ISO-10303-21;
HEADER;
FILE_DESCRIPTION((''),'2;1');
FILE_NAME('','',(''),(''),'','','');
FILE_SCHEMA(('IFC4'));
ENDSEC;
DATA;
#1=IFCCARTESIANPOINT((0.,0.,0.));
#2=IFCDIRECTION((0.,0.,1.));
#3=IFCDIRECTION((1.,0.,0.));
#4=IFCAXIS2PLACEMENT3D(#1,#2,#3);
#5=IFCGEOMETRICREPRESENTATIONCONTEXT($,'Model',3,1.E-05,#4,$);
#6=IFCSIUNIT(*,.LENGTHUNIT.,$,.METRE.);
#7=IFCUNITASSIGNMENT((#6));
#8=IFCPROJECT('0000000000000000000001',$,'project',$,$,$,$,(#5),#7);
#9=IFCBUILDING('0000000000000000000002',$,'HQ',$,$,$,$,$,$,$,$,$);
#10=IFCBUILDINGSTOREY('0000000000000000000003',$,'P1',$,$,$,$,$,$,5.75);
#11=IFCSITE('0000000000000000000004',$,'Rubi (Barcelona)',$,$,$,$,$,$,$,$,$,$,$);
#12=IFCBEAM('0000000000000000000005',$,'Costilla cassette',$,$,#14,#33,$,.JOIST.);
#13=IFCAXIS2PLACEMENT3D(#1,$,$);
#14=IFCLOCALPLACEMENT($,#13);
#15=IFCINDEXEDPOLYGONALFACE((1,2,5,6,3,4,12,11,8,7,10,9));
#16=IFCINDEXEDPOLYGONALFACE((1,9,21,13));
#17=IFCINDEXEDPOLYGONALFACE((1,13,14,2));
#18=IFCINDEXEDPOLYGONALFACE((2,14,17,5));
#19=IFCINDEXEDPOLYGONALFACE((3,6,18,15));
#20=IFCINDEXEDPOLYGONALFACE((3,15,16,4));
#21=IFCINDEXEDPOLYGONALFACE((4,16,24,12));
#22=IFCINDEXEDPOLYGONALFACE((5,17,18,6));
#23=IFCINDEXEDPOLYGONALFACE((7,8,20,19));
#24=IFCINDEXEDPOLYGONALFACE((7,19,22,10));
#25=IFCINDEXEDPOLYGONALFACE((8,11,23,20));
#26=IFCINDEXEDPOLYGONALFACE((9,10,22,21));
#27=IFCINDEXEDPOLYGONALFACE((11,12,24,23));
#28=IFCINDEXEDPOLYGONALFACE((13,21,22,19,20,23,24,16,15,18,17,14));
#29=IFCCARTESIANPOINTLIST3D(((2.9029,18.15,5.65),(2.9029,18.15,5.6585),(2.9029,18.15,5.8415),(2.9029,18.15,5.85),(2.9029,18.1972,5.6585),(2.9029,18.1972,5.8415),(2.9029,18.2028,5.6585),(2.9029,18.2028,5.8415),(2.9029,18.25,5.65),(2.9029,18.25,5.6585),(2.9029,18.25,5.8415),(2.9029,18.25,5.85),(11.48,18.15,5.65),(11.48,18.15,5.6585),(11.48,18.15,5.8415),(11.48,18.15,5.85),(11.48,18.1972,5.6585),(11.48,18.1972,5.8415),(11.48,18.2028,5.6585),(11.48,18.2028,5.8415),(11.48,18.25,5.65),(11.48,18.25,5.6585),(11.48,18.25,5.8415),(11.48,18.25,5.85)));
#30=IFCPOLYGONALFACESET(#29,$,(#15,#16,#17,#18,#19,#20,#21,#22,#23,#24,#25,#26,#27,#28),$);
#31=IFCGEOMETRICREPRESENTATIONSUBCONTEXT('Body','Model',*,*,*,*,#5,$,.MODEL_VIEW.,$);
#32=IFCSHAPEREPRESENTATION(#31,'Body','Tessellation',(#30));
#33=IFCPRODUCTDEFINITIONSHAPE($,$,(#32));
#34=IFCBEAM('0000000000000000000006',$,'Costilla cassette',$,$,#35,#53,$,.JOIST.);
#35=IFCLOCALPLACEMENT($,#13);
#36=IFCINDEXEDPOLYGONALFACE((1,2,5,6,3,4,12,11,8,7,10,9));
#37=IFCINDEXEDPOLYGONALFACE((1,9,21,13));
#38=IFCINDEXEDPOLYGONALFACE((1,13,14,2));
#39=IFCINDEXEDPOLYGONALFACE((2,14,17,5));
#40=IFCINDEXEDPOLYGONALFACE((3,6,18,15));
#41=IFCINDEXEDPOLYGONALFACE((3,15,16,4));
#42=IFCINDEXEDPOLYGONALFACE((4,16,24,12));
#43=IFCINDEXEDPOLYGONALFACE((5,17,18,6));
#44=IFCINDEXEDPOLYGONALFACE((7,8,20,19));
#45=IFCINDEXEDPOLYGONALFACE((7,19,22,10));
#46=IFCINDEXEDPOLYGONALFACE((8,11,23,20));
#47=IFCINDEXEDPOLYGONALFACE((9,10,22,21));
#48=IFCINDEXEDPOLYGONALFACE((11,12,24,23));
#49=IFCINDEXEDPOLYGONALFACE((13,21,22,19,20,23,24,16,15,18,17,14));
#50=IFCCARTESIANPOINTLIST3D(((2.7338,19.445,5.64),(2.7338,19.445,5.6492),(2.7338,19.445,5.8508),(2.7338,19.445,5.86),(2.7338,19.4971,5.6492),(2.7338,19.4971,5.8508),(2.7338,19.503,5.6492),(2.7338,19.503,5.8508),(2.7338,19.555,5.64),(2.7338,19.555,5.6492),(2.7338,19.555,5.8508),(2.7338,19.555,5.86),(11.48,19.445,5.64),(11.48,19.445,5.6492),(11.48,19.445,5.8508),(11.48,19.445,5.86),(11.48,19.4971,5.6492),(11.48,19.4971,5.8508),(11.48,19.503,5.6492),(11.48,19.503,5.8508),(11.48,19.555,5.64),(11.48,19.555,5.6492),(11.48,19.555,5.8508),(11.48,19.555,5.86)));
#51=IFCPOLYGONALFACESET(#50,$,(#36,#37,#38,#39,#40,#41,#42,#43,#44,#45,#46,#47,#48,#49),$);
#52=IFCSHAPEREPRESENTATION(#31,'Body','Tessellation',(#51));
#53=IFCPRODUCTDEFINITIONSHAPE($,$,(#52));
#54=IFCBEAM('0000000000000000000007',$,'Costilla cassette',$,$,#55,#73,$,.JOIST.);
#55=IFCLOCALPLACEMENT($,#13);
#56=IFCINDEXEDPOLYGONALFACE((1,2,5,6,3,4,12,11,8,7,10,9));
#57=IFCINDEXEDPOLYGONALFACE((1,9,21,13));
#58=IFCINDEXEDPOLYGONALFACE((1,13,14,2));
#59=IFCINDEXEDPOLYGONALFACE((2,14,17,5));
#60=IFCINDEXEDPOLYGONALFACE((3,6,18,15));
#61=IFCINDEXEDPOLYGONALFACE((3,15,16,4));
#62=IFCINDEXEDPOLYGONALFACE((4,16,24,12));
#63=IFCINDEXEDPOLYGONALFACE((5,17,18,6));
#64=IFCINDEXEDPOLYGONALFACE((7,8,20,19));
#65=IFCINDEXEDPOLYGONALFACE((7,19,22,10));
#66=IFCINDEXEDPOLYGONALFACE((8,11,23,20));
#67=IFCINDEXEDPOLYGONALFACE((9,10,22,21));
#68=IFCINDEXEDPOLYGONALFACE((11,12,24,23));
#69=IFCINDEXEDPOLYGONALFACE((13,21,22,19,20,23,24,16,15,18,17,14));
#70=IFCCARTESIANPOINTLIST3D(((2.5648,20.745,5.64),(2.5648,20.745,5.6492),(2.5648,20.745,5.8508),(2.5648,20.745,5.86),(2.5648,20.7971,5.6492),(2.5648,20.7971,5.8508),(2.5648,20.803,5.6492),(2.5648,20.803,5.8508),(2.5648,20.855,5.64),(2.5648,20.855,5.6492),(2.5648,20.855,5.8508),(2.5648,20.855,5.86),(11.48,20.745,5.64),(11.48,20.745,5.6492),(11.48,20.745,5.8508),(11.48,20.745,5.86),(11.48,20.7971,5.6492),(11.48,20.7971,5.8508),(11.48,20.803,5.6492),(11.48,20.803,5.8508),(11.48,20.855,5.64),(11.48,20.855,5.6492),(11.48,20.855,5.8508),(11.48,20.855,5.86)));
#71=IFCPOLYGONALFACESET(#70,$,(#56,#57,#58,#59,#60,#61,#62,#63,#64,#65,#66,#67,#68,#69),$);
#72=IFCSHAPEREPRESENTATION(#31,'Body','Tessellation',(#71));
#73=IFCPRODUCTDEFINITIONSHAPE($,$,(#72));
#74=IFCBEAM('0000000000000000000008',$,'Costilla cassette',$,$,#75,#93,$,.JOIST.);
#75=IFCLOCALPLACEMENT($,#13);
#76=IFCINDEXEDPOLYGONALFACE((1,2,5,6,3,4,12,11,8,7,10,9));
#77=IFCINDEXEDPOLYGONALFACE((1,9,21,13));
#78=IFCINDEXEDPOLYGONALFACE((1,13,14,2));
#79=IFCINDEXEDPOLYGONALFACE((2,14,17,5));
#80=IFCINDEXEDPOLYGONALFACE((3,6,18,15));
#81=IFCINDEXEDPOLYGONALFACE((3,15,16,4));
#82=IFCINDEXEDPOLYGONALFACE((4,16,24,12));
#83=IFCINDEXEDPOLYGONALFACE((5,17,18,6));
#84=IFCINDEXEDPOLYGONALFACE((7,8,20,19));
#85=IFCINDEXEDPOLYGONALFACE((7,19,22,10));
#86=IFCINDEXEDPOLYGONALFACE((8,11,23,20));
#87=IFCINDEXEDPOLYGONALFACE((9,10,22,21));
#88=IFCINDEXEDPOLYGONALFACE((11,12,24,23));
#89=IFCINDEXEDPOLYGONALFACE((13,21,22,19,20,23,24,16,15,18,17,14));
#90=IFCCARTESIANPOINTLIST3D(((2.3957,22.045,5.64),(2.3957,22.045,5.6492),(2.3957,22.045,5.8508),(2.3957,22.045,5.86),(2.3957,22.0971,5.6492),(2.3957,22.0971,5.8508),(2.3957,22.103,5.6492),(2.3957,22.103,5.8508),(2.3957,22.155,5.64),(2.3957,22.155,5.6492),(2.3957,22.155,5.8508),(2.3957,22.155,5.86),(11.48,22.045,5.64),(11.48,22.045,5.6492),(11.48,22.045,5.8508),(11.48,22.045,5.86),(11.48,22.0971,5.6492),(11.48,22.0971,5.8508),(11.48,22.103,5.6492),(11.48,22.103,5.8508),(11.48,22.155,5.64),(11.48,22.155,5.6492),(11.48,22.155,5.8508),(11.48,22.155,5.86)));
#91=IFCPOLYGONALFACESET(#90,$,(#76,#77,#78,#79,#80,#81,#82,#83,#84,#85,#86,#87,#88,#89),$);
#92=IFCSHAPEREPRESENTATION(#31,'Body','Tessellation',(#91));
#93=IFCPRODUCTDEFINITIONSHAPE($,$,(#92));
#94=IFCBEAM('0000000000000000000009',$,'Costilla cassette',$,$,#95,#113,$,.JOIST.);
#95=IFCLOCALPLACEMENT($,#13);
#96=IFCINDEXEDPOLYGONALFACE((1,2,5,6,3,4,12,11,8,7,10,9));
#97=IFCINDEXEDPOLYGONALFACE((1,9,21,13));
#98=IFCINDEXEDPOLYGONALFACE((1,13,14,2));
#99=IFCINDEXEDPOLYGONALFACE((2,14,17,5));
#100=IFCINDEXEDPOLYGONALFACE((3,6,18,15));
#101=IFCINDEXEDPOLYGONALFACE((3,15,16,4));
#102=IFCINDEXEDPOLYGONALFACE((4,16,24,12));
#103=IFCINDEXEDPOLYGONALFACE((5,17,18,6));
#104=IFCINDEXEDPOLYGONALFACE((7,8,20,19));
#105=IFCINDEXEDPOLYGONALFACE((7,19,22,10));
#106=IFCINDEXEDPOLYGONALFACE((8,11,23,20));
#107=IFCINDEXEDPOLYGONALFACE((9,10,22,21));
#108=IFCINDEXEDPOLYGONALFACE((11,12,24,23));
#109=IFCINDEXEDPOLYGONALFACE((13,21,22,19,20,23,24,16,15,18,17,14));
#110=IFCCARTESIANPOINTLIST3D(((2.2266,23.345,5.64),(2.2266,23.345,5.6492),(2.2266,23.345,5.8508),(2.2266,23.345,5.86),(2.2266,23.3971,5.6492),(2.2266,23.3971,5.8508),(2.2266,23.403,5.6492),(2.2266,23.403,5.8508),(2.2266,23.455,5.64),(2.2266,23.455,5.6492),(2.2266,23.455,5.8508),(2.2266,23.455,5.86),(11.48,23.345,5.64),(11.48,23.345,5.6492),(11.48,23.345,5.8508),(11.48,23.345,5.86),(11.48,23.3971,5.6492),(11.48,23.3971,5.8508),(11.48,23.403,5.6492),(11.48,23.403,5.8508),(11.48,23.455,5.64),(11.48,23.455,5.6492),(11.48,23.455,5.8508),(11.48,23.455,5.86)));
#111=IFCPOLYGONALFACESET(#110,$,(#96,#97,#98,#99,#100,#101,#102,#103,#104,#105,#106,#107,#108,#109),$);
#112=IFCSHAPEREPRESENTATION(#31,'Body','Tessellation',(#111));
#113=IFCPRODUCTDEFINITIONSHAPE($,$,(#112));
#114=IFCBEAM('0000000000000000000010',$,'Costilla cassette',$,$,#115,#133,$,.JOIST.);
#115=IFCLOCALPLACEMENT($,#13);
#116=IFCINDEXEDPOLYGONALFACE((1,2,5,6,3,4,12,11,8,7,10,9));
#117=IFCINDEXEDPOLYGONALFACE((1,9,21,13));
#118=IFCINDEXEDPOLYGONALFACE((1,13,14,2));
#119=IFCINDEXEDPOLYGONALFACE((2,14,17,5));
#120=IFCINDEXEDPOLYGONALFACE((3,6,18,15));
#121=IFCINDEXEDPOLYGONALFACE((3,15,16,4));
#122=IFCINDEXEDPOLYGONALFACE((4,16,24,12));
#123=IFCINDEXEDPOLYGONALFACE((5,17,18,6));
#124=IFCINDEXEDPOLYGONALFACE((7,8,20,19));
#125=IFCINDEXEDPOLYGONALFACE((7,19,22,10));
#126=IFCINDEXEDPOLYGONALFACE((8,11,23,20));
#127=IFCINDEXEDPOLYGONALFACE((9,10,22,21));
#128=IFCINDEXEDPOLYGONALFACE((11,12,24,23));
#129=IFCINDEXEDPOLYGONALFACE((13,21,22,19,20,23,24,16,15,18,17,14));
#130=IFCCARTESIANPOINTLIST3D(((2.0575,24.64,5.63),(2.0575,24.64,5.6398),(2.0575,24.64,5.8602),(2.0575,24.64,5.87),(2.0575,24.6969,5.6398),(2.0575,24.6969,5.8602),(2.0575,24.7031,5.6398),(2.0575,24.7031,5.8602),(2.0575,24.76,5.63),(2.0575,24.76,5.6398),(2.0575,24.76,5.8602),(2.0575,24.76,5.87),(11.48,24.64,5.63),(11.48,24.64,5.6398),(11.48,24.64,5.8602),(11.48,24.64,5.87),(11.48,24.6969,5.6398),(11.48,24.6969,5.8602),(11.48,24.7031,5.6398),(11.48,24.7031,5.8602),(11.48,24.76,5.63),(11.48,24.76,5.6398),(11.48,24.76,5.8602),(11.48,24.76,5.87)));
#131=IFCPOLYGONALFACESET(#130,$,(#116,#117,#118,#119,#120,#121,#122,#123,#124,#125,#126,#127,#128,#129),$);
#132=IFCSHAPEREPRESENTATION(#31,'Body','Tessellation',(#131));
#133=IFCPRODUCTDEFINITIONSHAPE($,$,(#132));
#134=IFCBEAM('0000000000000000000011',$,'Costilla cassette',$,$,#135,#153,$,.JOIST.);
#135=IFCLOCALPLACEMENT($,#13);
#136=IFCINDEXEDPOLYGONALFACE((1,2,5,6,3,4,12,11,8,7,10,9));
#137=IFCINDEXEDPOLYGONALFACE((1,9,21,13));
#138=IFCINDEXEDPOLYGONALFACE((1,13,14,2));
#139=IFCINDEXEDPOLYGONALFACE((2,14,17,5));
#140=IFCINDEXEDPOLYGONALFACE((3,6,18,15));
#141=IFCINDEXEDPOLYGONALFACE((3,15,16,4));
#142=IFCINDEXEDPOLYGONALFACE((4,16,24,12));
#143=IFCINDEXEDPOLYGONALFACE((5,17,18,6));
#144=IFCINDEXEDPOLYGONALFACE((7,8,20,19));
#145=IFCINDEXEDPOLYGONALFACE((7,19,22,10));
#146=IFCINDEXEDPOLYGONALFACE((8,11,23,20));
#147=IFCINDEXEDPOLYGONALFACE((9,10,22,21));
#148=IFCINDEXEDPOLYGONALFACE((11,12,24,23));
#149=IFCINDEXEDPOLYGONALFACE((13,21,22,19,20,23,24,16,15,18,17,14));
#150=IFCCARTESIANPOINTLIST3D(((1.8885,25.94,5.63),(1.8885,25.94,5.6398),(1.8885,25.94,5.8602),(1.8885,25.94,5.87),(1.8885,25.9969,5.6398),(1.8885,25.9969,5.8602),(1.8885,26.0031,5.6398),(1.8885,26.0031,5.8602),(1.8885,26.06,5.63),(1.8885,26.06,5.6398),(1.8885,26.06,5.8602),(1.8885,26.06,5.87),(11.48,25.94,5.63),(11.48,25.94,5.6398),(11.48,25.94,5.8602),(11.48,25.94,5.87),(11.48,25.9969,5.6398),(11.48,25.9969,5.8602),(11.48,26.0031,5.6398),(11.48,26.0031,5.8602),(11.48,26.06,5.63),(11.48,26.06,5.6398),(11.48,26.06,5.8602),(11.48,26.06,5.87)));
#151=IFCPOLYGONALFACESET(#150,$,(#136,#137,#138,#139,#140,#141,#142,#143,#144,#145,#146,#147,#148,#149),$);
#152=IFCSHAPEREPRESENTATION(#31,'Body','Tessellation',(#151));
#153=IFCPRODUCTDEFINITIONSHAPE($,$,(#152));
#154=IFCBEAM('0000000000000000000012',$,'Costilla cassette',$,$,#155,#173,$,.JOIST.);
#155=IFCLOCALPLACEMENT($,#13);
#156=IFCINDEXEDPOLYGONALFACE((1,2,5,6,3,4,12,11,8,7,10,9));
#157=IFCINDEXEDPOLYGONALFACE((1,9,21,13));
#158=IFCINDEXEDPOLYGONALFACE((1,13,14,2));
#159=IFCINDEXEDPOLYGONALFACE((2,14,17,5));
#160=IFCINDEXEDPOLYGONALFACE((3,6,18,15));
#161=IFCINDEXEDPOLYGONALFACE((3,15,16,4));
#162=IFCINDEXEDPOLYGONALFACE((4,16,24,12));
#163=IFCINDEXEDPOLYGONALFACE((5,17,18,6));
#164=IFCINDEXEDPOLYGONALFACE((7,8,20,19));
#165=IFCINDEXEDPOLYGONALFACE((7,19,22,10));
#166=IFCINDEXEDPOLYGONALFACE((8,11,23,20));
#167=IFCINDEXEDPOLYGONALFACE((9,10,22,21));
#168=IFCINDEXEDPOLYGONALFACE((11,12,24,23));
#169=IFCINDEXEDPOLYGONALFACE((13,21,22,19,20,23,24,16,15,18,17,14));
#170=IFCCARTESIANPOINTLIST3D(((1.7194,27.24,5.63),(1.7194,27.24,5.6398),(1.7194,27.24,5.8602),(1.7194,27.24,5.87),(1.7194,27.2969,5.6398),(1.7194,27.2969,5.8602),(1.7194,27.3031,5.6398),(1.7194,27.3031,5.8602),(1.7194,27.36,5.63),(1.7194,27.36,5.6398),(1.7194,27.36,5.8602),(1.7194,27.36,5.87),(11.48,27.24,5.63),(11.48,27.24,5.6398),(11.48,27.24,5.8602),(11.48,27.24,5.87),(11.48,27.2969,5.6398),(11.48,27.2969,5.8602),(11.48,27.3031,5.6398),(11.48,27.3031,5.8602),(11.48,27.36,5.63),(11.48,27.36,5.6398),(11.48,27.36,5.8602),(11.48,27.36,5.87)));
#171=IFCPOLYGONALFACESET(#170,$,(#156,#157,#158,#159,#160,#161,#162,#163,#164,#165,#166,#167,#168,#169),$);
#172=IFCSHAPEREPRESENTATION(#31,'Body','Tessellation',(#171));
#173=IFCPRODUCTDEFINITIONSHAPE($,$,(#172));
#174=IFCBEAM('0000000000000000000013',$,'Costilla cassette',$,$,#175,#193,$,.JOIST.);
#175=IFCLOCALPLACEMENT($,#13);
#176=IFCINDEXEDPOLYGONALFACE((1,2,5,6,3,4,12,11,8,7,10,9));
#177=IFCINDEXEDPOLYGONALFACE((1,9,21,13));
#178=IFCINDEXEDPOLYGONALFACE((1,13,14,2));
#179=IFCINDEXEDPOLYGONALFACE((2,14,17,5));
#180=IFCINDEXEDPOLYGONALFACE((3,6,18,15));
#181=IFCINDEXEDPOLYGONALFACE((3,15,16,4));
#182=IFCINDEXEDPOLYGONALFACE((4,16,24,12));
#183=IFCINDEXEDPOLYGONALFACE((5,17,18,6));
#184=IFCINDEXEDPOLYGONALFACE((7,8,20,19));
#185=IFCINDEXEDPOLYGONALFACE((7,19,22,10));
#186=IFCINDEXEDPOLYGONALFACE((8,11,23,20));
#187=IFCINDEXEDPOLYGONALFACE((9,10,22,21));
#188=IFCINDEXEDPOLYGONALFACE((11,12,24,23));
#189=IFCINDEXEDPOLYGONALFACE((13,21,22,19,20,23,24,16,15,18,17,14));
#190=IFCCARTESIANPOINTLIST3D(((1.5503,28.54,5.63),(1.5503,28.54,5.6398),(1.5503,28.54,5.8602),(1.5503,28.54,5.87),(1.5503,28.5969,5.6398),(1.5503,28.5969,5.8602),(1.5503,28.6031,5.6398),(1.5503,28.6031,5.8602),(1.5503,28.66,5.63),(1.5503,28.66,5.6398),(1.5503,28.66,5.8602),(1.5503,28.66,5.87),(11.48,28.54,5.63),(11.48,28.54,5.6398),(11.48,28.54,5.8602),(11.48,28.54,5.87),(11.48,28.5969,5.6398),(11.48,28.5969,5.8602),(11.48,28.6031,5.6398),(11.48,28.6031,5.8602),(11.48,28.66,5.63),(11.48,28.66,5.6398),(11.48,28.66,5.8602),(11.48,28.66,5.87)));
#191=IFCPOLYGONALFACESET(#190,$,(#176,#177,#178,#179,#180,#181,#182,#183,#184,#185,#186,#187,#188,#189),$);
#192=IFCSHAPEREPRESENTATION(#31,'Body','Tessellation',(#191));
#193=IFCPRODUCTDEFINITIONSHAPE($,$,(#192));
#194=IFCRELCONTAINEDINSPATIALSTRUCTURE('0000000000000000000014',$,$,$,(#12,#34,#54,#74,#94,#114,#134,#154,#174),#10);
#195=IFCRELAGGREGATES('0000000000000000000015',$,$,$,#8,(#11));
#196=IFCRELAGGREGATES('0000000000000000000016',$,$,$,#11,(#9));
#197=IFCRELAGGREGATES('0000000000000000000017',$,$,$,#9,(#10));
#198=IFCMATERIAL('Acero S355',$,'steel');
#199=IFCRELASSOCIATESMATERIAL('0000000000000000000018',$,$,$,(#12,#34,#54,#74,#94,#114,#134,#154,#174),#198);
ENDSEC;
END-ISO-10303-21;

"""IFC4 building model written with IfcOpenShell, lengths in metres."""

from ifc_helpers import new_model, si_unit, frame, origin_with_axes, place, context, subcontext, project, spatial, i_section, extrude, material, element, save


model = new_model("IFC4")

# Units and contexts
model_context = context("Model", 3, precision=1e-05, world=origin_with_axes())
body_context = subcontext(model_context, "Body", "Model", "MODEL_VIEW")
ifc_project = project(units=[si_unit("LENGTHUNIT", "METRE")], contexts=[model_context])

# Site, building, storey
site = spatial("IfcSite", under=ifc_project, Name="Rubi (Barcelona)")
building = spatial("IfcBuilding", under=site, Name="HQ")
storey = spatial("IfcBuildingStorey", under=building, Name="P1", Elevation=5.75)

# Beams
ifc_material_1 = material(Name="Acero S355", Category="steel")
beam_1_placement = place(None, origin_with_axes())
element("IfcBeam", 1, at=beam_1_placement, inside=storey, material=ifc_material_1, Name="Costilla cassette", PredefinedType="JOIST", context=body_context, shape_type="SweptSolid", body=[
    extrude(i_section(OverallWidth=0.1, OverallDepth=0.2, WebThickness=0.0056, FlangeThickness=0.0085), frame((2.9029, 18.2, 5.75), z_axis=(1.0, 0.0, 0.0), x_axis=(0.0, 1.0, 0.0)), (0.0, 0.0, 1.0), 8.5771),
])
beam_2_placement = place(None, origin_with_axes())
element("IfcBeam", 2, at=beam_2_placement, inside=storey, material=ifc_material_1, Name="Costilla cassette", PredefinedType="JOIST", context=body_context, shape_type="SweptSolid", body=[
    extrude(i_section(OverallWidth=0.11, OverallDepth=0.22, WebThickness=0.0059, FlangeThickness=0.0092), frame((2.7338, 19.5, 5.75), z_axis=(1.0, 0.0, 0.0), x_axis=(0.0, 1.0, 0.0)), (0.0, 0.0, 1.0), 8.7462),
])
beam_3_placement = place(None, origin_with_axes())
element("IfcBeam", 3, at=beam_3_placement, inside=storey, material=ifc_material_1, Name="Costilla cassette", PredefinedType="JOIST", context=body_context, shape_type="SweptSolid", body=[
    extrude(i_section(OverallWidth=0.11, OverallDepth=0.22, WebThickness=0.0059, FlangeThickness=0.0092), frame((2.5648, 20.8, 5.75), z_axis=(1.0, 0.0, 0.0), x_axis=(0.0, 1.0, 0.0)), (0.0, 0.0, 1.0), 8.9152),
])
beam_4_placement = place(None, origin_with_axes())
element("IfcBeam", 4, at=beam_4_placement, inside=storey, material=ifc_material_1, Name="Costilla cassette", PredefinedType="JOIST", context=body_context, shape_type="SweptSolid", body=[
    extrude(i_section(OverallWidth=0.11, OverallDepth=0.22, WebThickness=0.0059, FlangeThickness=0.0092), frame((2.3957, 22.1, 5.75), z_axis=(1.0, 0.0, 0.0), x_axis=(0.0, 1.0, 0.0)), (0.0, 0.0, 1.0), 9.0843),
])
beam_5_placement = place(None, origin_with_axes())
element("IfcBeam", 5, at=beam_5_placement, inside=storey, material=ifc_material_1, Name="Costilla cassette", PredefinedType="JOIST", context=body_context, shape_type="SweptSolid", body=[
    extrude(i_section(OverallWidth=0.11, OverallDepth=0.22, WebThickness=0.0059, FlangeThickness=0.0092), frame((2.2266, 23.4, 5.75), z_axis=(1.0, 0.0, 0.0), x_axis=(0.0, 1.0, 0.0)), (0.0, 0.0, 1.0), 9.2534),
])
beam_6_placement = place(None, origin_with_axes())
element("IfcBeam", 6, at=beam_6_placement, inside=storey, material=ifc_material_1, Name="Costilla cassette", PredefinedType="JOIST", context=body_context, shape_type="SweptSolid", body=[
    extrude(i_section(OverallWidth=0.12, OverallDepth=0.24, WebThickness=0.0062, FlangeThickness=0.0098), frame((2.0575, 24.7, 5.75), z_axis=(1.0, 0.0, 0.0), x_axis=(0.0, 1.0, 0.0)), (0.0, 0.0, 1.0), 9.4225),
])
beam_7_placement = place(None, origin_with_axes())
element("IfcBeam", 7, at=beam_7_placement, inside=storey, material=ifc_material_1, Name="Costilla cassette", PredefinedType="JOIST", context=body_context, shape_type="SweptSolid", body=[
    extrude(i_section(OverallWidth=0.12, OverallDepth=0.24, WebThickness=0.0062, FlangeThickness=0.0098), frame((1.8885, 26.0, 5.75), z_axis=(1.0, 0.0, 0.0), x_axis=(0.0, 1.0, 0.0)), (0.0, 0.0, 1.0), 9.5915),
])
beam_8_placement = place(None, origin_with_axes())
element("IfcBeam", 8, at=beam_8_placement, inside=storey, material=ifc_material_1, Name="Costilla cassette", PredefinedType="JOIST", context=body_context, shape_type="SweptSolid", body=[
    extrude(i_section(OverallWidth=0.12, OverallDepth=0.24, WebThickness=0.0062, FlangeThickness=0.0098), frame((1.7194, 27.3, 5.75), z_axis=(1.0, 0.0, 0.0), x_axis=(0.0, 1.0, 0.0)), (0.0, 0.0, 1.0), 9.7606),
])
beam_9_placement = place(None, origin_with_axes())
element("IfcBeam", 9, at=beam_9_placement, inside=storey, material=ifc_material_1, Name="Costilla cassette", PredefinedType="JOIST", context=body_context, shape_type="SweptSolid", body=[
    extrude(i_section(OverallWidth=0.12, OverallDepth=0.24, WebThickness=0.0062, FlangeThickness=0.0098), frame((1.5503, 28.6, 5.75), z_axis=(1.0, 0.0, 0.0), x_axis=(0.0, 1.0, 0.0)), (0.0, 0.0, 1.0), 9.9297),
])

save(model, "model.ifc")
